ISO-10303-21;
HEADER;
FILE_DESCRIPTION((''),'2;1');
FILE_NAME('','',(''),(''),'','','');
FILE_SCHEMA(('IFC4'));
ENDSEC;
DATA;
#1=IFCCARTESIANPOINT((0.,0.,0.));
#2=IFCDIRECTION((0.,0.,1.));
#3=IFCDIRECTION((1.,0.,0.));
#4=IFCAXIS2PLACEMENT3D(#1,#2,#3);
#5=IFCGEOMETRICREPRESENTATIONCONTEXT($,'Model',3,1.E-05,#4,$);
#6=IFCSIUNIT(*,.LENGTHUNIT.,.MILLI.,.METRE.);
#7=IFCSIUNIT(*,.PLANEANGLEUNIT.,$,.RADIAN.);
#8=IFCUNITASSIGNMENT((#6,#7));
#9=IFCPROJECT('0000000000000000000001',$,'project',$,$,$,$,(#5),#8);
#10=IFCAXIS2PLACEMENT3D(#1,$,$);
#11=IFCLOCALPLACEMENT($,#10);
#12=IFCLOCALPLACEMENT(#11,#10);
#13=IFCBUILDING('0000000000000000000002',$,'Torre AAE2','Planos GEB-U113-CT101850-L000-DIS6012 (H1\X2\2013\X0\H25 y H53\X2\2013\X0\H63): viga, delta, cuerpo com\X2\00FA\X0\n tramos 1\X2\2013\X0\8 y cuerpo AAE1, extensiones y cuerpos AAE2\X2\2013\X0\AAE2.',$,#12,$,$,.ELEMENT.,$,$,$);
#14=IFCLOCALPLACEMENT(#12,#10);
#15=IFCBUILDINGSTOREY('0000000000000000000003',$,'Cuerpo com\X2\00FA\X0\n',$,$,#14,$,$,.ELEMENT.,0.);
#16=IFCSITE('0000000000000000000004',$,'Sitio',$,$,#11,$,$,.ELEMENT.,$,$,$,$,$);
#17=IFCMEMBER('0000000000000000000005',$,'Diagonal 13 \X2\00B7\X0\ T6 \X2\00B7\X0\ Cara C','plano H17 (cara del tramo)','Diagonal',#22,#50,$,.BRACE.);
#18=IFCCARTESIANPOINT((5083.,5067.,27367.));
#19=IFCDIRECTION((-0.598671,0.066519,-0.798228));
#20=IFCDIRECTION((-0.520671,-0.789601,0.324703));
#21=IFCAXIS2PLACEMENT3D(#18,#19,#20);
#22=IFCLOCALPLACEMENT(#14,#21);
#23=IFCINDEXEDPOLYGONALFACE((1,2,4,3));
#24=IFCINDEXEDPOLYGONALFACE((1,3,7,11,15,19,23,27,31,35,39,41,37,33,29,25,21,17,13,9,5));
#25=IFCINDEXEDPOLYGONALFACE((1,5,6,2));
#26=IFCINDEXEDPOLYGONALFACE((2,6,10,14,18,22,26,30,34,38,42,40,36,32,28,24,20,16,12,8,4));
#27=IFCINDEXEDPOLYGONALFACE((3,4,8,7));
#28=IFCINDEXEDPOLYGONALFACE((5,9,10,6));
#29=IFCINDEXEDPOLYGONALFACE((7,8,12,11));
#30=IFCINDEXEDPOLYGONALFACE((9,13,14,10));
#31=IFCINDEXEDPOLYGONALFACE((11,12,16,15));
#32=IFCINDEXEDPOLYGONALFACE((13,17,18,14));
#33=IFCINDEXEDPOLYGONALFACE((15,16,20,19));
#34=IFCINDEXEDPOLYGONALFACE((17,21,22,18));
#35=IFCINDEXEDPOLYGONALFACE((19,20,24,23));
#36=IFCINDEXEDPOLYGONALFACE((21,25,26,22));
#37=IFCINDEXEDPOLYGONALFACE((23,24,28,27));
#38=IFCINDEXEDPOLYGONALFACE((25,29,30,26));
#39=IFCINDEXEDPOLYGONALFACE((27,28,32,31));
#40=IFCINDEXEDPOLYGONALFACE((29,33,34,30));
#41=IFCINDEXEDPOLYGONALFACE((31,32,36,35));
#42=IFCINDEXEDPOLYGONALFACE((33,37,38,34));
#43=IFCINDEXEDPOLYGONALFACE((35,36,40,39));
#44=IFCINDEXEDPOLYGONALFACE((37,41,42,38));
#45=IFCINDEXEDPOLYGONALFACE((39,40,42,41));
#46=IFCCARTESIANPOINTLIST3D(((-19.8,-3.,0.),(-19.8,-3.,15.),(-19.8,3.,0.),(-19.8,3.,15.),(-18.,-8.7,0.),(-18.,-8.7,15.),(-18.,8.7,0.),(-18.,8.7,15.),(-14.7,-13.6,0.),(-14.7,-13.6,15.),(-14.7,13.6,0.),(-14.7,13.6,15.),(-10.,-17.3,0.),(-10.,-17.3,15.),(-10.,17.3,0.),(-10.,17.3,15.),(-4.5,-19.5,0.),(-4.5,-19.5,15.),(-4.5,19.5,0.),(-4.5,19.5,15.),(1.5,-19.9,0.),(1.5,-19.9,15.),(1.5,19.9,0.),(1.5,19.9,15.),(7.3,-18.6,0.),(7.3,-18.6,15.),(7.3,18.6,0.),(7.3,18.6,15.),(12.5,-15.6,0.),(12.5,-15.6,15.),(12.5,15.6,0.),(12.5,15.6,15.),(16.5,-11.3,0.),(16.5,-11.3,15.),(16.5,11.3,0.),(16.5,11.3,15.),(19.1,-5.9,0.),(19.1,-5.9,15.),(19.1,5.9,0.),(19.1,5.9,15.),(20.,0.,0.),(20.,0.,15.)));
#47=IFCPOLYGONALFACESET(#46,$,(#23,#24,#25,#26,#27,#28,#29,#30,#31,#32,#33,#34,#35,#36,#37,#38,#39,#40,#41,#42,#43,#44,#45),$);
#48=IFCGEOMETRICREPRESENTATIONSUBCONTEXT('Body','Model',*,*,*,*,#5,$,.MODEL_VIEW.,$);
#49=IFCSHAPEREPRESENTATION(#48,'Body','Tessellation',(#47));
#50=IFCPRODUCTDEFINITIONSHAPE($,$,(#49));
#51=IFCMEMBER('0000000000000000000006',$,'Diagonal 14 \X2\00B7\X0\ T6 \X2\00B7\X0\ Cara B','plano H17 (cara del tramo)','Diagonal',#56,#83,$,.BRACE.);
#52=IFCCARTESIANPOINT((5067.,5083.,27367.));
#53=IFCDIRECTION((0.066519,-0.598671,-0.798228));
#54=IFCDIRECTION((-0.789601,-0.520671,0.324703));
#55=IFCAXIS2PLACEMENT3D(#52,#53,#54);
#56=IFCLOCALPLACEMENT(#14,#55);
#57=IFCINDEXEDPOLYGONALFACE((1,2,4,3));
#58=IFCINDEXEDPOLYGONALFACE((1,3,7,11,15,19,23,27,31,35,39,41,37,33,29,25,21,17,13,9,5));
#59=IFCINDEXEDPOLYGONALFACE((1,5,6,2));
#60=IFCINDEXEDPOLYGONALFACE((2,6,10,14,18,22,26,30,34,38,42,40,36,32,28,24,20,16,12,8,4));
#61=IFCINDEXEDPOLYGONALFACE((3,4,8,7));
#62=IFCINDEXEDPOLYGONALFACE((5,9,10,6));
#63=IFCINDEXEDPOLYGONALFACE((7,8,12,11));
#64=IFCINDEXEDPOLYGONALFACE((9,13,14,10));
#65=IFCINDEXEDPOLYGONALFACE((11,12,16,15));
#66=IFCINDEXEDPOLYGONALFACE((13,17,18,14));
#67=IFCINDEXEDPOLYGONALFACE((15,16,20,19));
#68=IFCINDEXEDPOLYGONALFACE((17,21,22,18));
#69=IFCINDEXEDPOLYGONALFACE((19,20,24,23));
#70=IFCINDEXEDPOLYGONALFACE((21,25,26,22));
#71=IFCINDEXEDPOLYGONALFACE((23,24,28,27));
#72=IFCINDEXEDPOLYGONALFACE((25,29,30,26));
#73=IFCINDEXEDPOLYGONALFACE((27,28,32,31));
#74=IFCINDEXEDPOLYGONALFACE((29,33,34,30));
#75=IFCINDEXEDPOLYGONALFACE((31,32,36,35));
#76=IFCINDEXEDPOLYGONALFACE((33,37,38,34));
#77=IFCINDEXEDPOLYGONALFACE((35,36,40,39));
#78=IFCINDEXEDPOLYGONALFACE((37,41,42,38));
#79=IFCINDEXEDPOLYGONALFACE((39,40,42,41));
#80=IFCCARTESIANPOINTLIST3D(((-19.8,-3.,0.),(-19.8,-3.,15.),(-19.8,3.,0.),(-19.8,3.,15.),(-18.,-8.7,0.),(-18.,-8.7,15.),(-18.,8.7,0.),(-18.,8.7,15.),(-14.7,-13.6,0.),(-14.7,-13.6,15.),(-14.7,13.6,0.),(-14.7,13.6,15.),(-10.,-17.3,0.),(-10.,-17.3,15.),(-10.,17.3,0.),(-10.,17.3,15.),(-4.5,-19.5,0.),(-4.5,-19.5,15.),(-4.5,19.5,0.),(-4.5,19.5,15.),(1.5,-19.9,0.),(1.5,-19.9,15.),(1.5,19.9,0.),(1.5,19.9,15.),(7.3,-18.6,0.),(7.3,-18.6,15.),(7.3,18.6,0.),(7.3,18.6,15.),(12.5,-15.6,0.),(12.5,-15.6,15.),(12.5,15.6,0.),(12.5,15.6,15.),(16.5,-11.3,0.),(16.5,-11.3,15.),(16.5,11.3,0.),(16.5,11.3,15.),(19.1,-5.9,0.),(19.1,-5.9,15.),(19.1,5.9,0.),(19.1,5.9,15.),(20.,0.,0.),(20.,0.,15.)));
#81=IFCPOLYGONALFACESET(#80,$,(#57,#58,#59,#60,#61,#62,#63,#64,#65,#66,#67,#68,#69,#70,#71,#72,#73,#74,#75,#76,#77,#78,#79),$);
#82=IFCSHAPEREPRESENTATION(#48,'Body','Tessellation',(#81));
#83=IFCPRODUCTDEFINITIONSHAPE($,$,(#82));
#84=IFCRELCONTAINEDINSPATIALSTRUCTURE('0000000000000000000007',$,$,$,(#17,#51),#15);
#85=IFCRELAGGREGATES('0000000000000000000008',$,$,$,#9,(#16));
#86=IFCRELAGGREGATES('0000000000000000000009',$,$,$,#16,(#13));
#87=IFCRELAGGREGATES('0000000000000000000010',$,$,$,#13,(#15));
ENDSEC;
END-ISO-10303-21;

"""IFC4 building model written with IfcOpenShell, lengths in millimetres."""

from ifc_helpers import new_model, si_unit, frame, origin, origin_with_axes, place, context, subcontext, project, spatial, circle, extrude, element, save


model = new_model("IFC4")

# Units and contexts
model_context = context("Model", 3, precision=1e-05, world=origin_with_axes())
body_context = subcontext(model_context, "Body", "Model", "MODEL_VIEW")
ifc_project = project(units=[si_unit("LENGTHUNIT", "METRE", prefix="MILLI"), si_unit("PLANEANGLEUNIT", "RADIAN")], contexts=[model_context])

# Site, building, storey
site_placement = place(None, origin())
site = spatial("IfcSite", under=ifc_project, at=site_placement, Name="Sitio", CompositionType="ELEMENT")
building_placement = place(site_placement, origin())
building = spatial("IfcBuilding", under=site, at=building_placement, Name="Torre AAE2", Description="Planos GEB-U113-CT101850-L000-DIS6012 (H1–H25 y H53–H63): viga, delta, cuerpo común tramos 1–8 y cuerpo AAE1, extensiones y cuerpos AAE2–AAE2.", CompositionType="ELEMENT")
storey_placement = place(building_placement, origin())
storey = spatial("IfcBuildingStorey", under=building, at=storey_placement, Name="Cuerpo común", CompositionType="ELEMENT", Elevation=0.0)

# Members
for number, where, z_axis, x_axis, name in (
    (1, (5083.0, 5067.0, 27367.0), (-0.598671, 0.066519, -0.798228), (-0.520671, -0.789601, 0.324703), "Diagonal 13 · T6 · Cara C"),
    (2, (5067.0, 5083.0, 27367.0), (0.066519, -0.598671, -0.798228), (-0.789601, -0.520671, 0.324703), "Diagonal 14 · T6 · Cara B"),
):
    element("IfcMember", number, at=place(storey_placement, frame(where, z_axis=z_axis, x_axis=x_axis)), inside=storey, Name=name, Description="plano H17 (cara del tramo)", ObjectType="Diagonal", PredefinedType="BRACE", context=body_context, shape_type="SweptSolid", body=[
        extrude(circle(Radius=20.0), None, (0.0, 0.0, 1.0), 15.0),
    ])

save(model, "model.ifc")
